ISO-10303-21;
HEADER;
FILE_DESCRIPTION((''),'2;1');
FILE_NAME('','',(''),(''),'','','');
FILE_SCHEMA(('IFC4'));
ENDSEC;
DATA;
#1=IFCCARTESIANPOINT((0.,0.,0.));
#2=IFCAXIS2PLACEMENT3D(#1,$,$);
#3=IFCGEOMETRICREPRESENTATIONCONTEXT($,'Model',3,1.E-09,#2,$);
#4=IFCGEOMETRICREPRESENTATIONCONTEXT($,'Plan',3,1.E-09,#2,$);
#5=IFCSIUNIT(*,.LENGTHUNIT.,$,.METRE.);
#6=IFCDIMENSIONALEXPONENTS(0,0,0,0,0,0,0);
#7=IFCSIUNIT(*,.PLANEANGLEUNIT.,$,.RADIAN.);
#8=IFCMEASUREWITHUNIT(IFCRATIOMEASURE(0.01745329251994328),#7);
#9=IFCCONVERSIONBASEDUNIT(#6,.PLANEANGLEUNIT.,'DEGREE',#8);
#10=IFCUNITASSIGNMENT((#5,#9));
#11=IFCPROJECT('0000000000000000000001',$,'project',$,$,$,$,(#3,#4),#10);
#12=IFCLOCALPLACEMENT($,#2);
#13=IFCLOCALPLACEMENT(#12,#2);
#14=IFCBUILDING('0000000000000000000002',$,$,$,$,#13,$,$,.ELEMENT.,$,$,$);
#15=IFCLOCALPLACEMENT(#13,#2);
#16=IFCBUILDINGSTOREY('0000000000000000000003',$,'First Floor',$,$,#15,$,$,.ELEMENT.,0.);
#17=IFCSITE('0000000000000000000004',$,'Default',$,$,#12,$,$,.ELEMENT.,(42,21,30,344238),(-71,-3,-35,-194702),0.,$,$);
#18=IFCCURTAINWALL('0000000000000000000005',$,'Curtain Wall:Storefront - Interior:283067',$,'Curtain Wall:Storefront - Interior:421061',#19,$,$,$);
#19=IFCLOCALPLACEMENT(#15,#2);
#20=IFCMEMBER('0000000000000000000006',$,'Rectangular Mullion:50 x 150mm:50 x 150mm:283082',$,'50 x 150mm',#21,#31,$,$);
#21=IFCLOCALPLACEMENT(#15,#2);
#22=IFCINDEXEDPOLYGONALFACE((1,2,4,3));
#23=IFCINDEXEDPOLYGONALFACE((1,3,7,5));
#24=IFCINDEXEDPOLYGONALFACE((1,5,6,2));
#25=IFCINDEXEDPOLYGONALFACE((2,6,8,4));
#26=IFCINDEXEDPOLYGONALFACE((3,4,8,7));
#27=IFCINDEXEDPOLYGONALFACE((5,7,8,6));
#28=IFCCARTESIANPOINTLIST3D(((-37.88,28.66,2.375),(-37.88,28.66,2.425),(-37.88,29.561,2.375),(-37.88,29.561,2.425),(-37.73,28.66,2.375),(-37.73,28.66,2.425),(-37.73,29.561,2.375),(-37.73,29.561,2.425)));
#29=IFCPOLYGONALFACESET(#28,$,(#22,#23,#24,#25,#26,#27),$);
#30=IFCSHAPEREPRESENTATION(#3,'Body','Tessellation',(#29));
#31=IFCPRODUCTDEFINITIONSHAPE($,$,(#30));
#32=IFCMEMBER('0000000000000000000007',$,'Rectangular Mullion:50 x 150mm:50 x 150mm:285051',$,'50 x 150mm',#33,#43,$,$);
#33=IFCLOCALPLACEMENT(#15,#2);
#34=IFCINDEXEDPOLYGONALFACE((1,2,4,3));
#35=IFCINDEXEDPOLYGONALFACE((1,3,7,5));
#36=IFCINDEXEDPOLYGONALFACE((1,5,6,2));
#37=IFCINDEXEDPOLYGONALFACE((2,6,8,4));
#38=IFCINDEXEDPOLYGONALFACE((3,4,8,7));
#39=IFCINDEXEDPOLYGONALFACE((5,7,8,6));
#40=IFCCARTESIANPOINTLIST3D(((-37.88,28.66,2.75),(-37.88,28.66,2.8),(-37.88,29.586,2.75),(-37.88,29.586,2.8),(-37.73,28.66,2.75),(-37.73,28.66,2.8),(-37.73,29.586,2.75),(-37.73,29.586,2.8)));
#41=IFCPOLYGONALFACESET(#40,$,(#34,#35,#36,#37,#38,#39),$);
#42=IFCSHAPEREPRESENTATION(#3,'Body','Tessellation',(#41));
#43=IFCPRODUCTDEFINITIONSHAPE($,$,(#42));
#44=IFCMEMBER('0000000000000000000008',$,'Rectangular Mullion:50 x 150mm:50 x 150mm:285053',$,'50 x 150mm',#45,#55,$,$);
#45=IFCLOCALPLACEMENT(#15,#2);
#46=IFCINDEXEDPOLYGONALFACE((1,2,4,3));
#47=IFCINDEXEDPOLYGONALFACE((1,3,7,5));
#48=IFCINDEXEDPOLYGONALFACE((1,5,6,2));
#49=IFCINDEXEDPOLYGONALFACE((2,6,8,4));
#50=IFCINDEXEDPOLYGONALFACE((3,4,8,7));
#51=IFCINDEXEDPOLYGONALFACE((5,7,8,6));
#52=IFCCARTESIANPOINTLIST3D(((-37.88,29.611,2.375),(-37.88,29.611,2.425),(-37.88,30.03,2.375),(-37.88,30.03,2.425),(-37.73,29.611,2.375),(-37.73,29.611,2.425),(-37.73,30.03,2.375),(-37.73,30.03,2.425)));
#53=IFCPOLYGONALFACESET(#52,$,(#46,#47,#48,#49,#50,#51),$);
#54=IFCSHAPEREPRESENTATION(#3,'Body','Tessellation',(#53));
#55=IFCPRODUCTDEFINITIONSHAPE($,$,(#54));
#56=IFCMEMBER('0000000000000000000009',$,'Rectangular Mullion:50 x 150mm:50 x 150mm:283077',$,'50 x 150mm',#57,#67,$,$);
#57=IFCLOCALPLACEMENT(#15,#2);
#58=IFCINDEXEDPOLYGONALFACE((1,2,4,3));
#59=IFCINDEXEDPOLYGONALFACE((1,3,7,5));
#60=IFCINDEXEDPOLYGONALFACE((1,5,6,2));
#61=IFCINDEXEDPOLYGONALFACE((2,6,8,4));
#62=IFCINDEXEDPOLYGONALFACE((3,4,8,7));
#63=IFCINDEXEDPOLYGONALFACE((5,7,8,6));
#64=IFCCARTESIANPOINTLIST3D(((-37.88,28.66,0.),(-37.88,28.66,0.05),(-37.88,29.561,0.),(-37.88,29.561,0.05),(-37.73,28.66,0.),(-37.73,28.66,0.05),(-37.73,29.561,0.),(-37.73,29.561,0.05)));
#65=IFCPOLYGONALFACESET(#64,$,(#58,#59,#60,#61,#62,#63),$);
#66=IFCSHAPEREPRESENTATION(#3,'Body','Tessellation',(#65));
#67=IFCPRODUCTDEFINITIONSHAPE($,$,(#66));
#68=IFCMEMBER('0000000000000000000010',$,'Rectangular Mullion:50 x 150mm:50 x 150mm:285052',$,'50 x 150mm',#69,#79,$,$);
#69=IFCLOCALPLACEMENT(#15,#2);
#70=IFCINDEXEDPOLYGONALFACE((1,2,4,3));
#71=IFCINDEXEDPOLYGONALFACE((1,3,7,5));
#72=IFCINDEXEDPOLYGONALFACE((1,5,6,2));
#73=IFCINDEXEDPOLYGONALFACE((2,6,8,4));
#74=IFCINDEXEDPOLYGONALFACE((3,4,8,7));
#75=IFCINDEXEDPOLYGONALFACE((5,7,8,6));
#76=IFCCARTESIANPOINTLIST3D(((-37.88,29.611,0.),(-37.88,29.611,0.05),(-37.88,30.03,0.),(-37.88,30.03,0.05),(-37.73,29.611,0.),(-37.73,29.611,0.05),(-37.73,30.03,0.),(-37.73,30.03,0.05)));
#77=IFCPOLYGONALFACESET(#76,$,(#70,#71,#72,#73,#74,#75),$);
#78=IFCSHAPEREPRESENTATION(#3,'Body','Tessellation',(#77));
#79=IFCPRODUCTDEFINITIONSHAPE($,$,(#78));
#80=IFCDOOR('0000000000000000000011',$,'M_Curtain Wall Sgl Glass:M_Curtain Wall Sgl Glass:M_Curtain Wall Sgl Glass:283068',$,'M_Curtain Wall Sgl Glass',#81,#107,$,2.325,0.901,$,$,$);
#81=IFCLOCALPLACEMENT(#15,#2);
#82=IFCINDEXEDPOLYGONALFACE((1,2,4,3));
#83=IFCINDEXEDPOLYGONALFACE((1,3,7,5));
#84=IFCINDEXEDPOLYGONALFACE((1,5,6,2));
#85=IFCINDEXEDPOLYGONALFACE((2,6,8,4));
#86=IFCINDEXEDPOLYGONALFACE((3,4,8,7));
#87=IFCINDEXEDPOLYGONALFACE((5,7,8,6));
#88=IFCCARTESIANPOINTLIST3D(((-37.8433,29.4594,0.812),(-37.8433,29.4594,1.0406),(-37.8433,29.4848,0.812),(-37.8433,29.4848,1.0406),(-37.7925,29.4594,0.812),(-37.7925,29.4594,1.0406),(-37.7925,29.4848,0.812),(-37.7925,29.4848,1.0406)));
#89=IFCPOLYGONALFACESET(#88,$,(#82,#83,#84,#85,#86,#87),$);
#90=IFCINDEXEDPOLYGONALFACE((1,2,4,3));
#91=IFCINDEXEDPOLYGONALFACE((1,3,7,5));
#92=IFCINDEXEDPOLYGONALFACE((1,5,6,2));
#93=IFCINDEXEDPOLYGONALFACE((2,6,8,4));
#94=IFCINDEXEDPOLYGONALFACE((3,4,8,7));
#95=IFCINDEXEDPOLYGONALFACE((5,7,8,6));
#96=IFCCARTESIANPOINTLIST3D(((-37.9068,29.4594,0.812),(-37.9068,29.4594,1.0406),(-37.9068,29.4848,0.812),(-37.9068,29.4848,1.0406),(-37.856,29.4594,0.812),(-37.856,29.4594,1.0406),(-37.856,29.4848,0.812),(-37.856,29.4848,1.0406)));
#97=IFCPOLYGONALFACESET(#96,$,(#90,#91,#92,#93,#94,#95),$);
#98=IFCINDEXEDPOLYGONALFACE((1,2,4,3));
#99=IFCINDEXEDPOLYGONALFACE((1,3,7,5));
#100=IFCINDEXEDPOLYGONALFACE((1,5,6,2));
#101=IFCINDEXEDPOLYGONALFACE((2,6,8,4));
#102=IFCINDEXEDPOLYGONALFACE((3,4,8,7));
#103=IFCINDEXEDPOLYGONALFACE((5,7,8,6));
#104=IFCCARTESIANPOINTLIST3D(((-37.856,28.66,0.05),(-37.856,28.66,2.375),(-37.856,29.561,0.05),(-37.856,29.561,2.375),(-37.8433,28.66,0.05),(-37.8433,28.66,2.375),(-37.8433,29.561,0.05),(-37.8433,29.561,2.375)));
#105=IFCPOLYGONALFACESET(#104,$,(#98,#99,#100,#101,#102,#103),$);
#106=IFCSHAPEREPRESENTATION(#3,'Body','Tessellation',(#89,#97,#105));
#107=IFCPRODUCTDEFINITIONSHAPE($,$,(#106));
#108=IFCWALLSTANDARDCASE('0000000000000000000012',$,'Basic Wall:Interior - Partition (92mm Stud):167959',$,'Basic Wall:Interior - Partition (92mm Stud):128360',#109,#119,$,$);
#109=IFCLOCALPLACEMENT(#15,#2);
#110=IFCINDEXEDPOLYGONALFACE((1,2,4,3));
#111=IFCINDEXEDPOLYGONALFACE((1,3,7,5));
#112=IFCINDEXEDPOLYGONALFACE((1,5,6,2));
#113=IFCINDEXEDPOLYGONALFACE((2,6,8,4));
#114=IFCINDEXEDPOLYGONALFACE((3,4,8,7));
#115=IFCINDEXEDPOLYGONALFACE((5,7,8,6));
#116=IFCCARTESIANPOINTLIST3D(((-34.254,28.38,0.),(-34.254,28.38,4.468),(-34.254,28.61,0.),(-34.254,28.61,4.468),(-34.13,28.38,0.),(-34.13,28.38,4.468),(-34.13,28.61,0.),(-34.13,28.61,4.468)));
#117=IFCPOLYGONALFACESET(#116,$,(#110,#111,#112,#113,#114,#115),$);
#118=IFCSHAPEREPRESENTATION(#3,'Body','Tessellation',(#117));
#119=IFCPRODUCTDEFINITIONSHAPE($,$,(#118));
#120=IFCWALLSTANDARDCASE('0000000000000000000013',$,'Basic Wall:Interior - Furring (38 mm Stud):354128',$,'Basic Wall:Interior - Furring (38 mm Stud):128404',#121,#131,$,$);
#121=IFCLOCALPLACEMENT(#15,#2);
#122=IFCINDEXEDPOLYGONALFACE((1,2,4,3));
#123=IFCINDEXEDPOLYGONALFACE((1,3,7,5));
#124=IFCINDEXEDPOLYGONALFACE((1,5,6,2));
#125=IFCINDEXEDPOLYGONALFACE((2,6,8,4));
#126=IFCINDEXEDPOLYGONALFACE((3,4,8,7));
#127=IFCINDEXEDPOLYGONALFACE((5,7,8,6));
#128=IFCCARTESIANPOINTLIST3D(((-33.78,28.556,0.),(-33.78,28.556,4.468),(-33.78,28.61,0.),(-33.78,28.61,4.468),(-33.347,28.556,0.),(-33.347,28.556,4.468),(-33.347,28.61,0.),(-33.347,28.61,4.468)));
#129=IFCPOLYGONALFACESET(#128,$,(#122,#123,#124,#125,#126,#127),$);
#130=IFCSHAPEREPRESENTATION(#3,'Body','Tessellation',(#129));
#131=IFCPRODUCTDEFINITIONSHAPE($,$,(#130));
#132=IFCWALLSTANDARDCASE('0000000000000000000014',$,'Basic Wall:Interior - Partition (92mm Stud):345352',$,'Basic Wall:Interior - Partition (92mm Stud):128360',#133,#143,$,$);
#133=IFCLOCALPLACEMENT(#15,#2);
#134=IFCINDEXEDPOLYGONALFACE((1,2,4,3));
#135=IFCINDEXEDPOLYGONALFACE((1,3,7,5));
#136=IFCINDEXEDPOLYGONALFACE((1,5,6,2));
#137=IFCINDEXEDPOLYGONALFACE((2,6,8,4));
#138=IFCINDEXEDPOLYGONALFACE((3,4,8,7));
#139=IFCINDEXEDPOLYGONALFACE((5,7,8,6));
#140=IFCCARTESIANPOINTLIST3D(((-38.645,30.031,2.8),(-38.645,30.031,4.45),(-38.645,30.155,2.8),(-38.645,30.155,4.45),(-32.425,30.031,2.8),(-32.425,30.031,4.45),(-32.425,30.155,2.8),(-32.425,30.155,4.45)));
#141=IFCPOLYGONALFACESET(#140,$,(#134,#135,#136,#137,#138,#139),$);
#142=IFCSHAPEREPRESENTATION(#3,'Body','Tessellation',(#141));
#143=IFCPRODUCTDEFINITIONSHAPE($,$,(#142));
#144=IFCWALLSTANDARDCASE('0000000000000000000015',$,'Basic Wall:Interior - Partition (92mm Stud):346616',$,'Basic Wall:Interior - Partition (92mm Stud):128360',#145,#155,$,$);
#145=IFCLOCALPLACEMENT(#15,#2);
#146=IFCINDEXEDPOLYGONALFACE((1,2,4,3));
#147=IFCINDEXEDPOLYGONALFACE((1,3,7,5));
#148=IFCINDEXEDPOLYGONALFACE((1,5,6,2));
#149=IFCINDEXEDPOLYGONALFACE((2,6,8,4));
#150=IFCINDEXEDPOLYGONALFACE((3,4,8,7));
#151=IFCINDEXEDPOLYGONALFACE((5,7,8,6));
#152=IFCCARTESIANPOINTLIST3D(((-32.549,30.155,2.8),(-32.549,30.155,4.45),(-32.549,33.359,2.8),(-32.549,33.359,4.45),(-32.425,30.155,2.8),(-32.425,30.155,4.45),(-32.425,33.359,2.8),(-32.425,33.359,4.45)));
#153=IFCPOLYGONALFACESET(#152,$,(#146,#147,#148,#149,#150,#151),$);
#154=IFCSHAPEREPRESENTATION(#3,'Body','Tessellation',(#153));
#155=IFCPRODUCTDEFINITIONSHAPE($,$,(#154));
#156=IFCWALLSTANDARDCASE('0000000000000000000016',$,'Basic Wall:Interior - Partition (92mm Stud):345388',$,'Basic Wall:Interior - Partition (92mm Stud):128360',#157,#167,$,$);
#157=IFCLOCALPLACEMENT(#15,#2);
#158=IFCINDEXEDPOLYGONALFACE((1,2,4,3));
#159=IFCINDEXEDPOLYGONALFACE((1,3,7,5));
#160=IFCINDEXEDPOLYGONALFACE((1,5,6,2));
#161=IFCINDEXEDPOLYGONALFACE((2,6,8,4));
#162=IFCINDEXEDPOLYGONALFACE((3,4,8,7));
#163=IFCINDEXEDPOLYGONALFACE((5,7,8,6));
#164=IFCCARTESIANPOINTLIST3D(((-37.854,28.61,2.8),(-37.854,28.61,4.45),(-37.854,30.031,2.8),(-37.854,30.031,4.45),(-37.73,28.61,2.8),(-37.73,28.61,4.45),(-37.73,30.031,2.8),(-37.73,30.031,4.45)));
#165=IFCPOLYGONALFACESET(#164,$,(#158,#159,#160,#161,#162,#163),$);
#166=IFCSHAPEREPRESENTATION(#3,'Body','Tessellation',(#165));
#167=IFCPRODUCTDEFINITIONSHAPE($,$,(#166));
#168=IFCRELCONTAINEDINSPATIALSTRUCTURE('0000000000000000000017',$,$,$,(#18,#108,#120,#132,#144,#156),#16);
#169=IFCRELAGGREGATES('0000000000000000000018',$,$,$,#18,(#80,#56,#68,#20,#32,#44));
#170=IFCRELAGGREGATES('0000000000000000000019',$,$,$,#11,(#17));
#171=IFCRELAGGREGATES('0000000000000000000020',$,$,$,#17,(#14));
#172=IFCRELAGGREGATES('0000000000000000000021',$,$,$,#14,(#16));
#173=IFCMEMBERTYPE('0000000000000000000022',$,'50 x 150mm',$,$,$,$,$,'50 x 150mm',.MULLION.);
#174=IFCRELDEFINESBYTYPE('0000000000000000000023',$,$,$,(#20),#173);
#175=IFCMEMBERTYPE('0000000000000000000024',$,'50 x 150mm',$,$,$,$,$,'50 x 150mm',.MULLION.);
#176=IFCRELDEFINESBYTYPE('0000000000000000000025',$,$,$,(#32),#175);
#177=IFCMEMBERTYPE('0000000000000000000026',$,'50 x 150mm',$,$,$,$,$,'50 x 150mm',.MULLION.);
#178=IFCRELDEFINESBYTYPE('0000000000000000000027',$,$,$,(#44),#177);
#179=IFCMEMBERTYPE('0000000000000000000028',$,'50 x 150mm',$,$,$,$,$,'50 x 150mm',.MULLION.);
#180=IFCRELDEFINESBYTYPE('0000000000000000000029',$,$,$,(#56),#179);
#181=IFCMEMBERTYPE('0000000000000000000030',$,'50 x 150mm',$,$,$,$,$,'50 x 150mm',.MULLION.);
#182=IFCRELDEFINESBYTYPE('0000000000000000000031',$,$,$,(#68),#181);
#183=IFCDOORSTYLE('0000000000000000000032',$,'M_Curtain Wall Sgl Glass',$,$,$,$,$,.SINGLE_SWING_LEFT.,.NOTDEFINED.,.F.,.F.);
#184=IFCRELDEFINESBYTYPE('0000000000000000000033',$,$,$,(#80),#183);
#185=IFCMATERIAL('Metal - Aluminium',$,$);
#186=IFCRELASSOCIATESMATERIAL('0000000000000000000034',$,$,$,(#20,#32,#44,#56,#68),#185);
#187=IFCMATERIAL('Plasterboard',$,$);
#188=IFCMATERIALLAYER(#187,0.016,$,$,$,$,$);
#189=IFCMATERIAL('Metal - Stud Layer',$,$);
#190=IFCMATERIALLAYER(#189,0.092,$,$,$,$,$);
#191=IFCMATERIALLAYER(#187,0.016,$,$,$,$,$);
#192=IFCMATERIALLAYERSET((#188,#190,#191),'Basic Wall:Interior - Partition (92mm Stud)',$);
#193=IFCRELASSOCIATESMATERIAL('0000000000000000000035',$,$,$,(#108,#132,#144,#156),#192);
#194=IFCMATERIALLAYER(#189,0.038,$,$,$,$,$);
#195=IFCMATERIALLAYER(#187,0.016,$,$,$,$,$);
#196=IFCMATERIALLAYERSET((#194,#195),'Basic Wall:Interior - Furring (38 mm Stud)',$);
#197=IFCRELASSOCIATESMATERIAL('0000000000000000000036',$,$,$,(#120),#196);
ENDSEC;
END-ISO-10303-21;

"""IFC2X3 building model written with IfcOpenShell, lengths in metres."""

from ifc_helpers import new_model, entity, si_unit, converted_unit, frame, frame_2d, origin, origin_2d_with_axis, place, context, project, spatial, rectangle, extrude, source, transform, mapped, material, layer, layer_set, layer_usage, type_object, type_shapes, element, aggregate, save


model = new_model("IFC2X3")

# Units and contexts
model_context = context("Model", 3, precision=1e-09, world=origin())
plan_context = context("Plan", 3, precision=1e-09, world=origin())
ifc_project = project(units=[si_unit("LENGTHUNIT", "METRE"), converted_unit("PLANEANGLEUNIT", "DEGREE", entity("IfcRatioMeasure", 0.01745329251994328), si_unit("PLANEANGLEUNIT", "RADIAN"), dimensions=[0, 0, 0, 0, 0, 0, 0])], contexts=[model_context, plan_context])

# Site, building, storey
site_placement = place(None, origin())
site = spatial("IfcSite", under=ifc_project, at=site_placement, Name="Default", CompositionType="ELEMENT", RefLatitude=(42, 21, 30, 344238), RefLongitude=(-71, -3, -35, -194702), RefElevation=0.0)
building_placement = place(site_placement, origin())
building = spatial("IfcBuilding", under=site, at=building_placement, CompositionType="ELEMENT")
storey_placement = place(building_placement, origin())
storey = spatial("IfcBuildingStorey", under=building, at=storey_placement, Name="First Floor", CompositionType="ELEMENT", Elevation=0.0)

# Curtain wall
curtain_wall_1_placement = place(storey_placement, origin())
curtain_wall_1 = element("IfcCurtainWall", 1, at=curtain_wall_1_placement, inside=storey, Name="Curtain Wall:Storefront - Interior:283067", ObjectType="Curtain Wall:Storefront - Interior:421061")
ifc_material_1 = material(Name="Metal - Aluminium")

# Members
member_type_1 = type_object("IfcMemberType", Name="50 x 150mm", ElementType="50 x 150mm", PredefinedType="MULLION")
shared_shape_1 = source(origin(), model_context, "Body", "SweptSolid", [
    extrude(rectangle(XDim=0.05, YDim=0.15, at=origin_2d_with_axis()), frame((0.0, 0.0, -0.901), z_axis=(0.0, 0.0, 1.0), x_axis=(-1.0, 0.0, 0.0)), (0.0, 0.0, 1.0), 0.901),
])
type_shapes(member_type_1, [shared_shape_1])
member_1_placement = place(storey_placement, frame((-37.805, 29.561, 2.4), z_axis=(0.0, 1.0, 0.0), x_axis=(0.0, 0.0, 1.0)))
member_1 = element("IfcMember", 2, at=member_1_placement, type_object=member_type_1, material=ifc_material_1, Name="Rectangular Mullion:50 x 150mm:50 x 150mm:283082", ObjectType="50 x 150mm", context=model_context, shape_type="MappedRepresentation", body=[
    mapped(shared_shape_1, transform((0.0, 0.0, 0.0), scale=1.0)),
])
member_type_2 = type_object("IfcMemberType", Name="50 x 150mm", ElementType="50 x 150mm", PredefinedType="MULLION")
shared_shape_2 = source(origin(), model_context, "Body", "SweptSolid", [
    extrude(rectangle(XDim=0.05, YDim=0.15, at=origin_2d_with_axis()), frame((-0.025, 0.0, -0.926), z_axis=(0.0, 0.0, 1.0), x_axis=(-1.0, 0.0, 0.0)), (0.0, 0.0, 1.0), 0.926),
])
type_shapes(member_type_2, [shared_shape_2])
member_2_placement = place(storey_placement, frame((-37.805, 29.586, 2.8), z_axis=(0.0, 1.0, 0.0), x_axis=(0.0, 0.0, 1.0)))
member_2 = element("IfcMember", 3, at=member_2_placement, type_object=member_type_2, material=ifc_material_1, Name="Rectangular Mullion:50 x 150mm:50 x 150mm:285051", ObjectType="50 x 150mm", context=model_context, shape_type="MappedRepresentation", body=[
    mapped(shared_shape_2, transform((0.0, 0.0, 0.0), scale=1.0)),
])
member_type_3 = type_object("IfcMemberType", Name="50 x 150mm", ElementType="50 x 150mm", PredefinedType="MULLION")
shared_shape_3 = source(origin(), model_context, "Body", "SweptSolid", [
    extrude(rectangle(XDim=0.05, YDim=0.15, at=origin_2d_with_axis()), frame((0.0, 0.0, -0.419), z_axis=(0.0, 0.0, 1.0), x_axis=(-1.0, 0.0, 0.0)), (0.0, 0.0, 1.0), 0.419),
])
type_shapes(member_type_3, [shared_shape_3])
member_3_placement = place(storey_placement, frame((-37.805, 30.03, 2.4), z_axis=(0.0, 1.0, 0.0), x_axis=(0.0, 0.0, 1.0)))
member_3 = element("IfcMember", 4, at=member_3_placement, type_object=member_type_3, material=ifc_material_1, Name="Rectangular Mullion:50 x 150mm:50 x 150mm:285053", ObjectType="50 x 150mm", context=model_context, shape_type="MappedRepresentation", body=[
    mapped(shared_shape_3, transform((0.0, 0.0, 0.0), scale=1.0)),
])
member_type_4 = type_object("IfcMemberType", Name="50 x 150mm", ElementType="50 x 150mm", PredefinedType="MULLION")
shared_shape_4 = source(origin(), model_context, "Body", "SweptSolid", [
    extrude(rectangle(XDim=0.05, YDim=0.15, at=origin_2d_with_axis()), frame((-0.025, 0.0, -0.901), z_axis=(0.0, 0.0, 1.0), x_axis=(-1.0, 0.0, 0.0)), (0.0, 0.0, 1.0), 0.901),
])
type_shapes(member_type_4, [shared_shape_4])
member_4_placement = place(storey_placement, frame((-37.805, 28.66, 0.0), z_axis=(0.0, -1.0, 0.0), x_axis=(0.0, 0.0, -1.0)))
member_4 = element("IfcMember", 5, at=member_4_placement, type_object=member_type_4, material=ifc_material_1, Name="Rectangular Mullion:50 x 150mm:50 x 150mm:283077", ObjectType="50 x 150mm", context=model_context, shape_type="MappedRepresentation", body=[
    mapped(shared_shape_4, transform((0.0, 0.0, 0.0), scale=1.0)),
])
member_type_5 = type_object("IfcMemberType", Name="50 x 150mm", ElementType="50 x 150mm", PredefinedType="MULLION")
shared_shape_5 = source(origin(), model_context, "Body", "SweptSolid", [
    extrude(rectangle(XDim=0.05, YDim=0.15, at=origin_2d_with_axis()), frame((-0.025, 0.0, -0.419), z_axis=(0.0, 0.0, 1.0), x_axis=(-1.0, 0.0, 0.0)), (0.0, 0.0, 1.0), 0.419),
])
type_shapes(member_type_5, [shared_shape_5])
member_5_placement = place(storey_placement, frame((-37.805, 29.611, 0.0), z_axis=(0.0, -1.0, 0.0), x_axis=(0.0, 0.0, -1.0)))
member_5 = element("IfcMember", 6, at=member_5_placement, type_object=member_type_5, material=ifc_material_1, Name="Rectangular Mullion:50 x 150mm:50 x 150mm:285052", ObjectType="50 x 150mm", context=model_context, shape_type="MappedRepresentation", body=[
    mapped(shared_shape_5, transform((0.0, 0.0, 0.0), scale=1.0)),
])

# Door
door_style = type_object("IfcDoorStyle", Name="M_Curtain Wall Sgl Glass", ConstructionType="NOTDEFINED", OperationType="SINGLE_SWING_LEFT", ParameterTakesPrecedence=False, Sizeable=False)
shared_shape_6 = source(origin(), model_context, "Body", "SweptSolid", [
    extrude(rectangle(XDim=0.0254, YDim=0.0508, at=origin_2d_with_axis()), frame((-0.3616, -0.0129, 0.762), z_axis=(0.0, 0.0, 1.0), x_axis=(-1.0, 0.0, 0.0)), (0.0, 0.0, 1.0), 0.2286),
    extrude(rectangle(XDim=0.0254, YDim=0.0508, at=origin_2d_with_axis()), frame((-0.3616, -0.0764, 0.762)), (0.0, 0.0, 1.0), 0.2286),
    extrude(rectangle(XDim=0.0127, YDim=0.901, at=origin_2d_with_axis()), frame((0.0, -0.0447, 0.0), z_axis=(0.0, 0.0, 1.0), x_axis=(0.0, 1.0, 0.0)), (0.0, 0.0, 1.0), 2.325),
])
type_shapes(door_style, [shared_shape_6])
door_1_placement = place(storey_placement, frame((-37.805, 29.1105, 0.05), z_axis=(0.0, 0.0, 1.0), x_axis=(0.0, -1.0, 0.0)))
door_1 = element("IfcDoor", 7, at=door_1_placement, type_object=door_style, Name="M_Curtain Wall Sgl Glass:M_Curtain Wall Sgl Glass:M_Curtain Wall Sgl Glass:283068", ObjectType="M_Curtain Wall Sgl Glass", OverallHeight=2.325, OverallWidth=0.901, context=model_context, shape_type="MappedRepresentation", body=[
    mapped(shared_shape_6, transform((0.0, 0.0, 0.0), scale=1.0)),
])
aggregate(curtain_wall_1, [door_1, member_4, member_5, member_1, member_2, member_3])

# Walls
ifc_material_2 = material(Name="Plasterboard")
ifc_layer_1 = layer(ifc_material_2, 0.016)
ifc_material_3 = material(Name="Metal - Stud Layer")
ifc_layer_2 = layer(ifc_material_3, 0.092)
ifc_layer_3 = layer(ifc_material_2, 0.016)
ifc_layer_set_1 = layer_set([ifc_layer_1, ifc_layer_2, ifc_layer_3], Name="Basic Wall:Interior - Partition (92mm Stud)")
ifc_layer_usage_1 = layer_usage(ifc_layer_set_1, "AXIS2", "NEGATIVE", 0.062)
wall_1_placement = place(storey_placement, frame((-34.192, 28.61, 0.0), z_axis=(0.0, 0.0, 1.0), x_axis=(0.0, -1.0, 0.0)))
element("IfcWallStandardCase", 8, at=wall_1_placement, inside=storey, material=ifc_layer_usage_1, Name="Basic Wall:Interior - Partition (92mm Stud):167959", ObjectType="Basic Wall:Interior - Partition (92mm Stud):128360", context=model_context, shape_type="SweptSolid", body=[
    extrude(rectangle(XDim=0.23, YDim=0.124, at=frame_2d((0.115, 0.0), x_axis=(-1.0, 0.0))), origin(), (0.0, 0.0, 1.0), 4.468),
])
ifc_layer_4 = layer(ifc_material_3, 0.038)
ifc_layer_5 = layer(ifc_material_2, 0.016)
ifc_layer_set_2 = layer_set([ifc_layer_4, ifc_layer_5], Name="Basic Wall:Interior - Furring (38 mm Stud)")
ifc_layer_usage_2 = layer_usage(ifc_layer_set_2, "AXIS2", "NEGATIVE", 0.027)
wall_2_placement = place(storey_placement, frame((-33.347, 28.583, 0.0), z_axis=(0.0, 0.0, 1.0), x_axis=(-1.0, 0.0, 0.0)))
element("IfcWallStandardCase", 9, at=wall_2_placement, inside=storey, material=ifc_layer_usage_2, Name="Basic Wall:Interior - Furring (38 mm Stud):354128", ObjectType="Basic Wall:Interior - Furring (38 mm Stud):128404", context=model_context, shape_type="SweptSolid", body=[
    extrude(rectangle(XDim=0.433, YDim=0.054, at=frame_2d((0.2165, 0.0), x_axis=(-1.0, 0.0))), origin(), (0.0, 0.0, 1.0), 4.468),
])
wall_3_placement = place(storey_placement, frame((-38.645, 30.093, 2.8)))
element("IfcWallStandardCase", 10, at=wall_3_placement, inside=storey, material=ifc_layer_usage_1, Name="Basic Wall:Interior - Partition (92mm Stud):345352", ObjectType="Basic Wall:Interior - Partition (92mm Stud):128360", context=model_context, shape_type="SweptSolid", body=[
    extrude(rectangle(XDim=6.22, YDim=0.124, at=frame_2d((3.11, 0.0), x_axis=(-1.0, 0.0))), origin(), (0.0, 0.0, 1.0), 1.65),
])
wall_4_placement = place(storey_placement, frame((-32.487, 30.155, 2.8), z_axis=(0.0, 0.0, 1.0), x_axis=(0.0, 1.0, 0.0)))
element("IfcWallStandardCase", 11, at=wall_4_placement, inside=storey, material=ifc_layer_usage_1, Name="Basic Wall:Interior - Partition (92mm Stud):346616", ObjectType="Basic Wall:Interior - Partition (92mm Stud):128360", context=model_context, shape_type="SweptSolid", body=[
    extrude(rectangle(XDim=3.204, YDim=0.124, at=frame_2d((1.602, 0.0), x_axis=(-1.0, 0.0))), origin(), (0.0, 0.0, 1.0), 1.65),
])
wall_5_placement = place(storey_placement, frame((-37.792, 30.031, 2.8), z_axis=(0.0, 0.0, 1.0), x_axis=(0.0, -1.0, 0.0)))
element("IfcWallStandardCase", 12, at=wall_5_placement, inside=storey, material=ifc_layer_usage_1, Name="Basic Wall:Interior - Partition (92mm Stud):345388", ObjectType="Basic Wall:Interior - Partition (92mm Stud):128360", context=model_context, shape_type="SweptSolid", body=[
    extrude(rectangle(XDim=1.421, YDim=0.124, at=frame_2d((0.7105, 0.0), x_axis=(-1.0, 0.0))), origin(), (0.0, 0.0, 1.0), 1.65),
])

save(model, "model.ifc")
